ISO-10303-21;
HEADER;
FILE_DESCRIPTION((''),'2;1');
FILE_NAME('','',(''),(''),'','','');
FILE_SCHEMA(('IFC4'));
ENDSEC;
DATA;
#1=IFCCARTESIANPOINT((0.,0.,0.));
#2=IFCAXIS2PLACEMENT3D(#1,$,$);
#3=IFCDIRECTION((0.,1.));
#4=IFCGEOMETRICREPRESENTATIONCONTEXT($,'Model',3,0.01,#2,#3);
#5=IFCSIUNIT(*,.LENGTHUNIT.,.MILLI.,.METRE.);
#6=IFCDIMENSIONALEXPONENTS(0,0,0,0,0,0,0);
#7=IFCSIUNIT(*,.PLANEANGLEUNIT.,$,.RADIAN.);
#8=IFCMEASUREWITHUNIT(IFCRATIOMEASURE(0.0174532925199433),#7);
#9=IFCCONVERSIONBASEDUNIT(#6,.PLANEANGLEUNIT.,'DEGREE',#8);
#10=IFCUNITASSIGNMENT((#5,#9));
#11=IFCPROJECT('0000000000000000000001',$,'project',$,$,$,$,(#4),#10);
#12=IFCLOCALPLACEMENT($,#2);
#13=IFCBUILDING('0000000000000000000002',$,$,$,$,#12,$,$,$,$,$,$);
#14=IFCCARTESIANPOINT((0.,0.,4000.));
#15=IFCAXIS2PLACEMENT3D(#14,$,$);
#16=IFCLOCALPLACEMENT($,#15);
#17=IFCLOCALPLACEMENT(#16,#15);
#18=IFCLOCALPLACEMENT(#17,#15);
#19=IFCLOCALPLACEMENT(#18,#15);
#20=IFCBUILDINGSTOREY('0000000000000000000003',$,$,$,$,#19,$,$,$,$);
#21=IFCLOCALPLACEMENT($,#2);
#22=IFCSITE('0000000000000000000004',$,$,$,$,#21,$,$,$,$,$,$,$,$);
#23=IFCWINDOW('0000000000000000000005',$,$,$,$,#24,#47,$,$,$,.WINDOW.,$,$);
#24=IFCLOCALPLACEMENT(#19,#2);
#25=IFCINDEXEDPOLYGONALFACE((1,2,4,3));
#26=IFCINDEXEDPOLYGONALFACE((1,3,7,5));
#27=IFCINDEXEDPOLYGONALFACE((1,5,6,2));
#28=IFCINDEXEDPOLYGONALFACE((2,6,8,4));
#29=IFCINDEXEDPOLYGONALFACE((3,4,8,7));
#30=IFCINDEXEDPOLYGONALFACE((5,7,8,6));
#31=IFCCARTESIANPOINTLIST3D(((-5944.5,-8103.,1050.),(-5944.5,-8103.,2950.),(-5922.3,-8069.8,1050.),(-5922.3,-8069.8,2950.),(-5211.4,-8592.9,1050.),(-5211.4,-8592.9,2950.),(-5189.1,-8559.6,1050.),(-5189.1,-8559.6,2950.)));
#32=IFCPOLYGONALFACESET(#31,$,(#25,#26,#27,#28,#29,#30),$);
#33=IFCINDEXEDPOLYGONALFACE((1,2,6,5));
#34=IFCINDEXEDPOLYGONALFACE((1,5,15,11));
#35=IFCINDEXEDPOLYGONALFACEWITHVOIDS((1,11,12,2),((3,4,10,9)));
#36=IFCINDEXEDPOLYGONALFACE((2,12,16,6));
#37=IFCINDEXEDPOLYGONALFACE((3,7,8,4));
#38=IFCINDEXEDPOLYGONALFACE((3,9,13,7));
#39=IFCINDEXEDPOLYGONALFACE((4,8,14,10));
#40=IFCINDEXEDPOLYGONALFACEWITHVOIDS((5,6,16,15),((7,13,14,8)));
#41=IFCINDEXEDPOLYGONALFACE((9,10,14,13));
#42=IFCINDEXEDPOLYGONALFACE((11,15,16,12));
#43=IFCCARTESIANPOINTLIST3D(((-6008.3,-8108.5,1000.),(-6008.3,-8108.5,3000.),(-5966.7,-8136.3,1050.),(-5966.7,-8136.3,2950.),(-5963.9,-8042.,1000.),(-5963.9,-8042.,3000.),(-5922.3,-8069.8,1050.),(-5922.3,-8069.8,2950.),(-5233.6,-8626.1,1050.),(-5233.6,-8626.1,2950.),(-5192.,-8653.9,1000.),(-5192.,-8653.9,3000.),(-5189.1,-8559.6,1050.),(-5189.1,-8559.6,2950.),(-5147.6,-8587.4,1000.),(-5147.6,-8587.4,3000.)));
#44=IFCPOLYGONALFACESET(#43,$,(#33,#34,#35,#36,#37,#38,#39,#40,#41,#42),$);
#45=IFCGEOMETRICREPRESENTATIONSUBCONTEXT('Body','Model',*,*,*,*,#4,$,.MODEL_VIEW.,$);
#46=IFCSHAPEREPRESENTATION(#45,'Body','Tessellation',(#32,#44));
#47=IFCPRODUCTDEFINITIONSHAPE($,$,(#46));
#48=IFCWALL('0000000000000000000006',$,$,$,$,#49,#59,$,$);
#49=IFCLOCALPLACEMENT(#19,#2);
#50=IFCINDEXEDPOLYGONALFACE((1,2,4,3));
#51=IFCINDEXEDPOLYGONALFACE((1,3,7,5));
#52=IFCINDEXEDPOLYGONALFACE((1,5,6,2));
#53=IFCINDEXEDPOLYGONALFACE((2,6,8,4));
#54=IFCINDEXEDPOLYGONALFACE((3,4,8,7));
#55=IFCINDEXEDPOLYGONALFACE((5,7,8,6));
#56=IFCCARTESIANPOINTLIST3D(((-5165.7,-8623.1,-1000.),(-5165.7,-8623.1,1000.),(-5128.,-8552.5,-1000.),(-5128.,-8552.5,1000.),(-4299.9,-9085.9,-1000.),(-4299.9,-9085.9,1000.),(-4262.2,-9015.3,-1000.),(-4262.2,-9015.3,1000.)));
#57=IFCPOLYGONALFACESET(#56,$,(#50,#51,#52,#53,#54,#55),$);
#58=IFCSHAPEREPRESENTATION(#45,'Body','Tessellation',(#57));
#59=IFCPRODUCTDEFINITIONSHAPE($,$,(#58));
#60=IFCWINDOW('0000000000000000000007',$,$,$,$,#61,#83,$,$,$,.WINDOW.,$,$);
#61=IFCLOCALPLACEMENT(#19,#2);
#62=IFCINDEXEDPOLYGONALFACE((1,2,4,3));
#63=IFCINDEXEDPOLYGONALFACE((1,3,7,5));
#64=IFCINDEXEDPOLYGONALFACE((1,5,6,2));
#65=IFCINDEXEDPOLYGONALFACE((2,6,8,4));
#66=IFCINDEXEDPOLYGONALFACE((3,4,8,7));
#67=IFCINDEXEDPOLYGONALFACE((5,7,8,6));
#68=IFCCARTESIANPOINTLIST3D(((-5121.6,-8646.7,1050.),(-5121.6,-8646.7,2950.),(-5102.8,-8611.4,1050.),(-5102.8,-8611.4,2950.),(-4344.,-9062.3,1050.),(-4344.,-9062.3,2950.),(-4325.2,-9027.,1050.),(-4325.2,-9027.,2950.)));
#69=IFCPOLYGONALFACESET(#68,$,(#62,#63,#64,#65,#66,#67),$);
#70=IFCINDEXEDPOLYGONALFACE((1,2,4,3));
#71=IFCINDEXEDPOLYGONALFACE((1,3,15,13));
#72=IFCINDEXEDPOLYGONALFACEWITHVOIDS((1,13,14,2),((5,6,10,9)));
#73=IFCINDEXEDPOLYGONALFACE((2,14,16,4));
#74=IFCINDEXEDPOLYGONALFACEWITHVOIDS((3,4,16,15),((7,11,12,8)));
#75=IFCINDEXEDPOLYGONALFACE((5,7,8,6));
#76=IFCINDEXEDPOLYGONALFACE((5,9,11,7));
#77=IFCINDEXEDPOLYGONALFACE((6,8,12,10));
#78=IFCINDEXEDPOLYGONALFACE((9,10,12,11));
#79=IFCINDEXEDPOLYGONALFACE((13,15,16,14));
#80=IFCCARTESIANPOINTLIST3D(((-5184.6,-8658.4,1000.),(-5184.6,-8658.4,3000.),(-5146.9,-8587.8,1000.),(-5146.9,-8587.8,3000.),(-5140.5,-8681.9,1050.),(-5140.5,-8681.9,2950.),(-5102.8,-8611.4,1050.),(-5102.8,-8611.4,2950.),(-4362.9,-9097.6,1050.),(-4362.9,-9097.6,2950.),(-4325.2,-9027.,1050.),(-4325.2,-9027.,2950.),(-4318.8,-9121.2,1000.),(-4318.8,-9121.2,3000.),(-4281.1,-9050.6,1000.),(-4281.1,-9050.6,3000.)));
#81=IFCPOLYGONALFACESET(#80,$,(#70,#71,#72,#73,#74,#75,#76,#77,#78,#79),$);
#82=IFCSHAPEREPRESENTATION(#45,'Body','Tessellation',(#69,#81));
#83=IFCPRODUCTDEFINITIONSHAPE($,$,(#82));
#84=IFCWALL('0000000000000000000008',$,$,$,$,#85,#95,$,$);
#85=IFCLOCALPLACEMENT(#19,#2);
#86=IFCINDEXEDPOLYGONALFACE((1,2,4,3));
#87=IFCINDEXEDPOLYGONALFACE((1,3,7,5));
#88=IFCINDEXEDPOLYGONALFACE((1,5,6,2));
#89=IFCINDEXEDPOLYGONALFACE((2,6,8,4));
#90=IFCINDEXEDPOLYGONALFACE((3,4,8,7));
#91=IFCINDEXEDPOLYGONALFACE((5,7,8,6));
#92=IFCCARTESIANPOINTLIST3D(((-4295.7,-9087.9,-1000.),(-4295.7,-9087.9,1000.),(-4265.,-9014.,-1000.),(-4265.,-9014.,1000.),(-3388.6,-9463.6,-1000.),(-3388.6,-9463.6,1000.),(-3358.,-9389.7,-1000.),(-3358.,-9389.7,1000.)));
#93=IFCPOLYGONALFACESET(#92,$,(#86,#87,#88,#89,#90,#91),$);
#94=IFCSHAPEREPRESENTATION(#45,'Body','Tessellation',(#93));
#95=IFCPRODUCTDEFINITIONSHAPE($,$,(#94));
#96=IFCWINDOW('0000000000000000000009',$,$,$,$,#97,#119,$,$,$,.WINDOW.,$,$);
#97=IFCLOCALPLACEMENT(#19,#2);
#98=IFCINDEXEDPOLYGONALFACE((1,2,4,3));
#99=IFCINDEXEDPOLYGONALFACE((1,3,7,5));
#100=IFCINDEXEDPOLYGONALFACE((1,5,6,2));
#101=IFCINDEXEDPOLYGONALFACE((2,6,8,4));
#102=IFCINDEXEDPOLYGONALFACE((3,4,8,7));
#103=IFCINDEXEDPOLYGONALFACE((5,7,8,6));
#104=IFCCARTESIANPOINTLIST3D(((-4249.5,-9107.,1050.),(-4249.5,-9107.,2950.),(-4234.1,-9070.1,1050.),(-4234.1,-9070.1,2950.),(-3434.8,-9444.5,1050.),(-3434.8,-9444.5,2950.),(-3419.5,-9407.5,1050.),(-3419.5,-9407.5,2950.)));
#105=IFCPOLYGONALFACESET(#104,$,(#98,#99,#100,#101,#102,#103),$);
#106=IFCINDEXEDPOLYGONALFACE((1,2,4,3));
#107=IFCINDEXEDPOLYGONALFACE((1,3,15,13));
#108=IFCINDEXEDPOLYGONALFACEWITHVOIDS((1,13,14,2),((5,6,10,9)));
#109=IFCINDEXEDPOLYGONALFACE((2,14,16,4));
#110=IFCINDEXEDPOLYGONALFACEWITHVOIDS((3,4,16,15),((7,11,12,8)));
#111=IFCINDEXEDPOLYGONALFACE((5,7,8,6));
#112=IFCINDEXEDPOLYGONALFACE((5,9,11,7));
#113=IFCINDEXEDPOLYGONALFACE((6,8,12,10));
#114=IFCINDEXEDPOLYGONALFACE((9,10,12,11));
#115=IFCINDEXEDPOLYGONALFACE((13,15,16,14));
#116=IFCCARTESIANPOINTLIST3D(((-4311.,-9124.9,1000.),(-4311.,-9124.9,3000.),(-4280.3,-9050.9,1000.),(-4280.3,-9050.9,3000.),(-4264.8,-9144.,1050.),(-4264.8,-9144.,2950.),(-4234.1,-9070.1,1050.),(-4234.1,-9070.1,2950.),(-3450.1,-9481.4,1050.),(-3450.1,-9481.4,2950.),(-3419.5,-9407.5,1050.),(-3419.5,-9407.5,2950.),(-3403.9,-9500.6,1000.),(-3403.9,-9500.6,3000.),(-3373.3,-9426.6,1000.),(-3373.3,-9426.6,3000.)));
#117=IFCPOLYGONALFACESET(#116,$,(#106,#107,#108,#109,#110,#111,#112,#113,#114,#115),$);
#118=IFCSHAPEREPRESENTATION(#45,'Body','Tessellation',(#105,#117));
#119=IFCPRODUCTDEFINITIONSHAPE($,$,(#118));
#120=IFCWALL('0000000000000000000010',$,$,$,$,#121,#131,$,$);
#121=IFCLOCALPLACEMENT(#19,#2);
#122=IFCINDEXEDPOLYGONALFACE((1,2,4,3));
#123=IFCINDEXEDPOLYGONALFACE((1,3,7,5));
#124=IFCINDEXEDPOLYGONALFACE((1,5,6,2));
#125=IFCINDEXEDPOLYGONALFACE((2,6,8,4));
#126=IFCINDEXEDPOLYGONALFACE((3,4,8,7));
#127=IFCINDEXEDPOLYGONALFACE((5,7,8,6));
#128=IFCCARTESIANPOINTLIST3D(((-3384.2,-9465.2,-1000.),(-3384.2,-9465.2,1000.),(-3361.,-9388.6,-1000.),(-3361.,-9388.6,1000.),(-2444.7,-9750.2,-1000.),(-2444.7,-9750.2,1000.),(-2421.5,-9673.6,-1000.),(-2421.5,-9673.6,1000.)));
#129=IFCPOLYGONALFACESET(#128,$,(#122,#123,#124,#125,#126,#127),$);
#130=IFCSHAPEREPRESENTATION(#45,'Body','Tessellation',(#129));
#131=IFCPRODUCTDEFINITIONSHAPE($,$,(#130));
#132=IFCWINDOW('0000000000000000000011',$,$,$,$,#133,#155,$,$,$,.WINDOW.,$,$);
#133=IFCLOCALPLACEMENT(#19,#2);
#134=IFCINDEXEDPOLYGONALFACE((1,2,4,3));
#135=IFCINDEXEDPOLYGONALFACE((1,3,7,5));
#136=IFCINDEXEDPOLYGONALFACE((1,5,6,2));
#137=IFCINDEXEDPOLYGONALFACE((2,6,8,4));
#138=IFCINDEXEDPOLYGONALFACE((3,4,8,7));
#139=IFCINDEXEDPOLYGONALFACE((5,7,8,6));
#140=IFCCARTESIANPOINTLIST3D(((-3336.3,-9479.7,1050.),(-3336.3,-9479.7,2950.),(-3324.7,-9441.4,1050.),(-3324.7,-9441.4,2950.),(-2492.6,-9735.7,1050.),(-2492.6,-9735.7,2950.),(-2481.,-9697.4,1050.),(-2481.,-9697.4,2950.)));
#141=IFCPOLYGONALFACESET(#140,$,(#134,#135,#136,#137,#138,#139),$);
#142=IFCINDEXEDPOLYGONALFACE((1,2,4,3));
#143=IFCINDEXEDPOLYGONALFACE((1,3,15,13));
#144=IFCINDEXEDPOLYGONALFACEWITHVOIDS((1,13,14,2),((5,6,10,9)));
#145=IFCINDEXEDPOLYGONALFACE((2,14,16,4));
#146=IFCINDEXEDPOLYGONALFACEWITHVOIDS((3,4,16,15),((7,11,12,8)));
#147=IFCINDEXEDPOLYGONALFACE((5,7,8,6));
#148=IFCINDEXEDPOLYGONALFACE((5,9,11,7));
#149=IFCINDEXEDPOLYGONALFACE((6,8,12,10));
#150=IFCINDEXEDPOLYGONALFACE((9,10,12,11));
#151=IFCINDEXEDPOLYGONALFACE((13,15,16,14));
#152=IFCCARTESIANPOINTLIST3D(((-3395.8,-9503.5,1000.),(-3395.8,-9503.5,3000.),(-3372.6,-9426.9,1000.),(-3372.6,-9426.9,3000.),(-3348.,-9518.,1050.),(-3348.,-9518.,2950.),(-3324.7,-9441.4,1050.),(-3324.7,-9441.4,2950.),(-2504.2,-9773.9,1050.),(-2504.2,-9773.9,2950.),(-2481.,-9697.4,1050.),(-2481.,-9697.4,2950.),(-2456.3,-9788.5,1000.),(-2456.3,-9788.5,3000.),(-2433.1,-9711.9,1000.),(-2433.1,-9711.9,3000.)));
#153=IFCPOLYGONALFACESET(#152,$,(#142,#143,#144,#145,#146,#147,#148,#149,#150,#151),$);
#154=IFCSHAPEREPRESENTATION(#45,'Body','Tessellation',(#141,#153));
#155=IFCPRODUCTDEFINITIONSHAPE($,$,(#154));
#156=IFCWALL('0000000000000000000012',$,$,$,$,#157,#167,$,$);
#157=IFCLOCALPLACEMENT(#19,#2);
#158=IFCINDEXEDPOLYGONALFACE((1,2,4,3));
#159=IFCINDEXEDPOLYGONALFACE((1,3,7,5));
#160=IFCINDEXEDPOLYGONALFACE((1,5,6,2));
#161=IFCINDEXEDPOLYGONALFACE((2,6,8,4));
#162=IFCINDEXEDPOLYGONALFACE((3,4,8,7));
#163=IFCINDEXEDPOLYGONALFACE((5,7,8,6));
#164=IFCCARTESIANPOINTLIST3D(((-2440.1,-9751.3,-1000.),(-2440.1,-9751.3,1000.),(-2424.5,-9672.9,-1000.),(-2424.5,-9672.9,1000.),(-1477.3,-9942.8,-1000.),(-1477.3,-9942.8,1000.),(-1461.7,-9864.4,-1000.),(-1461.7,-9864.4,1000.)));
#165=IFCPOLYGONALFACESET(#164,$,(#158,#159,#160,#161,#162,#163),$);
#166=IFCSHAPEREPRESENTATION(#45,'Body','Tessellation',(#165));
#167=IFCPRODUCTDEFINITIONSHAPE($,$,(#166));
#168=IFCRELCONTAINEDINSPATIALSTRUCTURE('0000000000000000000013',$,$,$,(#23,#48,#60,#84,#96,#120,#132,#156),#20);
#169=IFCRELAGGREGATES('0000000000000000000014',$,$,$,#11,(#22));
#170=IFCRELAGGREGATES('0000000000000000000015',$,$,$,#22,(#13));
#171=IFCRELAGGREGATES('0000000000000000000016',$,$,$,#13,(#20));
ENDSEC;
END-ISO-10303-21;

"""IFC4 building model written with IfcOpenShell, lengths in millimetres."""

from ifc_helpers import new_model, entity, si_unit, converted_unit, direction, frame, origin, origin_2d, place, context, subcontext, project, spatial, rectangle, extrude, element, save


model = new_model("IFC4")

# Units and contexts
model_context = context("Model", 3, precision=0.01, world=origin(), true_north=direction((0.0, 1.0)))
body_context = subcontext(model_context, "Body", "Model", "MODEL_VIEW")
ifc_project = project(units=[si_unit("LENGTHUNIT", "METRE", prefix="MILLI"), converted_unit("PLANEANGLEUNIT", "DEGREE", entity("IfcRatioMeasure", 0.0174532925199433), si_unit("PLANEANGLEUNIT", "RADIAN"), dimensions=[0, 0, 0, 0, 0, 0, 0])], contexts=[model_context])

# Site, building, storey
site_placement = place(None, origin())
site = spatial("IfcSite", under=ifc_project, at=site_placement)
building_placement = place(None, origin())
building = spatial("IfcBuilding", under=site, at=building_placement)
placement_1 = place(None, frame((0.0, 0.0, 4000.0)))
placement_2 = place(placement_1, frame((0.0, 0.0, 4000.0)))
placement_3 = place(placement_2, frame((0.0, 0.0, 4000.0)))
storey_placement = place(placement_3, frame((0.0, 0.0, 4000.0)))
storey = spatial("IfcBuildingStorey", under=building, at=storey_placement)

# Shared definitions
cartesian_point_1 = entity("IfcCartesianPoint", [-440.9, -950.0])
shared_polyline = entity("IfcPolyline", [cartesian_point_1, entity("IfcCartesianPoint", [-440.9, 950.0]), entity("IfcCartesianPoint", [-440.9, 950.0]), entity("IfcCartesianPoint", [440.9, 950.0]), entity("IfcCartesianPoint", [440.9, 950.0]), entity("IfcCartesianPoint", [440.9, -950.0]), entity("IfcCartesianPoint", [440.9, -950.0]), entity("IfcCartesianPoint", [-440.9, -950.0]), cartesian_point_1])

# Window
window_1_placement = place(storey_placement, frame((-5555.7, -8314.7, 2000.0), z_axis=(0.0, 0.0, 1.0), x_axis=(8314.694856, -5555.704226, 0.0)))
cartesian_point_2 = entity("IfcCartesianPoint", [-490.9, -1000.0])
element("IfcWindow", 1, at=window_1_placement, inside=storey, PredefinedType="WINDOW", context=body_context, shape_type="SweptSolid", body=[
    entity("IfcExtrudedAreaSolid", entity("IfcArbitraryClosedProfileDef", "AREA", None, shared_polyline), entity("IfcAxis2Placement3D", entity("IfcCartesianPoint", [0.0, 0.0, 0.0]), entity("IfcDirection", [0.0, -1.0, 0.0]), entity("IfcDirection", [1.0, 0.0, 0.0])), entity("IfcDirection", [0.0, 0.0, 1.0]), 40.0),
    entity("IfcExtrudedAreaSolid", entity("IfcArbitraryProfileDefWithVoids", "AREA", None, entity("IfcPolyline", [cartesian_point_2, entity("IfcCartesianPoint", [-490.9, 1000.0]), entity("IfcCartesianPoint", [-490.9, 1000.0]), entity("IfcCartesianPoint", [490.9, 1000.0]), entity("IfcCartesianPoint", [490.9, 1000.0]), entity("IfcCartesianPoint", [490.9, -1000.0]), entity("IfcCartesianPoint", [490.9, -1000.0]), entity("IfcCartesianPoint", [-490.9, -1000.0]), cartesian_point_2]), [shared_polyline]), entity("IfcAxis2Placement3D", entity("IfcCartesianPoint", [0.0, 0.0, 0.0]), entity("IfcDirection", [0.0, -1.0, 0.0]), entity("IfcDirection", [1.0, 0.0, 0.0])), entity("IfcDirection", [0.0, 0.0, 1.0]), 80.0),
])

# Wall
wall_1_placement = place(storey_placement, frame((-4714.0, -8819.2, -1000.0), z_axis=(0.0, 0.0, 1.0), x_axis=(8819.212881, -4713.966924, 0.0)))
element("IfcWall", 2, at=wall_1_placement, inside=storey, context=body_context, shape_type="SweptSolid", body=[
    extrude(rectangle(XDim=981.7, YDim=80.0, at=origin_2d()), origin(), (0.0, 0.0, 1.0), 2000.0),
])

# Window
window_2_placement = place(storey_placement, frame((-4714.0, -8819.2, 2000.0), z_axis=(0.0, 0.0, 1.0), x_axis=(8819.212881, -4713.966924, 0.0)))
cartesian_point_3 = entity("IfcCartesianPoint", [-490.9, -1000.0])
element("IfcWindow", 3, at=window_2_placement, inside=storey, PredefinedType="WINDOW", context=body_context, shape_type="SweptSolid", body=[
    entity("IfcExtrudedAreaSolid", entity("IfcArbitraryClosedProfileDef", "AREA", None, shared_polyline), entity("IfcAxis2Placement3D", entity("IfcCartesianPoint", [0.0, 0.0, 0.0]), entity("IfcDirection", [0.0, -1.0, 0.0]), entity("IfcDirection", [1.0, 0.0, 0.0])), entity("IfcDirection", [0.0, 0.0, 1.0]), 40.0),
    entity("IfcExtrudedAreaSolid", entity("IfcArbitraryProfileDefWithVoids", "AREA", None, entity("IfcPolyline", [cartesian_point_3, entity("IfcCartesianPoint", [-490.9, 1000.0]), entity("IfcCartesianPoint", [-490.9, 1000.0]), entity("IfcCartesianPoint", [490.9, 1000.0]), entity("IfcCartesianPoint", [490.9, 1000.0]), entity("IfcCartesianPoint", [490.9, -1000.0]), entity("IfcCartesianPoint", [490.9, -1000.0]), entity("IfcCartesianPoint", [-490.9, -1000.0]), cartesian_point_3]), [shared_polyline]), entity("IfcAxis2Placement3D", entity("IfcCartesianPoint", [0.0, 0.0, 0.0]), entity("IfcDirection", [0.0, -1.0, 0.0]), entity("IfcDirection", [1.0, 0.0, 0.0])), entity("IfcDirection", [0.0, 0.0, 1.0]), 80.0),
])

# Wall
wall_2_placement = place(storey_placement, frame((-3826.8, -9238.8, -1000.0), z_axis=(0.0, 0.0, 1.0), x_axis=(9238.794759, -3826.835691, 0.0)))
element("IfcWall", 4, at=wall_2_placement, inside=storey, context=body_context, shape_type="SweptSolid", body=[
    extrude(rectangle(XDim=981.7, YDim=80.0, at=origin_2d()), origin(), (0.0, 0.0, 1.0), 2000.0),
])

# Window
window_3_placement = place(storey_placement, frame((-3826.8, -9238.8, 2000.0), z_axis=(0.0, 0.0, 1.0), x_axis=(9238.794759, -3826.835691, 0.0)))
cartesian_point_4 = entity("IfcCartesianPoint", [-490.9, -1000.0])
element("IfcWindow", 5, at=window_3_placement, inside=storey, PredefinedType="WINDOW", context=body_context, shape_type="SweptSolid", body=[
    entity("IfcExtrudedAreaSolid", entity("IfcArbitraryClosedProfileDef", "AREA", None, shared_polyline), entity("IfcAxis2Placement3D", entity("IfcCartesianPoint", [0.0, 0.0, 0.0]), entity("IfcDirection", [0.0, -1.0, 0.0]), entity("IfcDirection", [1.0, 0.0, 0.0])), entity("IfcDirection", [0.0, 0.0, 1.0]), 40.0),
    entity("IfcExtrudedAreaSolid", entity("IfcArbitraryProfileDefWithVoids", "AREA", None, entity("IfcPolyline", [cartesian_point_4, entity("IfcCartesianPoint", [-490.9, 1000.0]), entity("IfcCartesianPoint", [-490.9, 1000.0]), entity("IfcCartesianPoint", [490.9, 1000.0]), entity("IfcCartesianPoint", [490.9, 1000.0]), entity("IfcCartesianPoint", [490.9, -1000.0]), entity("IfcCartesianPoint", [490.9, -1000.0]), entity("IfcCartesianPoint", [-490.9, -1000.0]), cartesian_point_4]), [shared_polyline]), entity("IfcAxis2Placement3D", entity("IfcCartesianPoint", [0.0, 0.0, 0.0]), entity("IfcDirection", [0.0, -1.0, 0.0]), entity("IfcDirection", [1.0, 0.0, 0.0])), entity("IfcDirection", [0.0, 0.0, 1.0]), 80.0),
])

# Wall
wall_3_placement = place(storey_placement, frame((-2902.8, -9569.4, -1000.0), z_axis=(0.0, 0.0, 1.0), x_axis=(9569.403736, -2902.845525, 0.0)))
element("IfcWall", 6, at=wall_3_placement, inside=storey, context=body_context, shape_type="SweptSolid", body=[
    extrude(rectangle(XDim=981.7, YDim=80.0, at=origin_2d()), origin(), (0.0, 0.0, 1.0), 2000.0),
])

# Window
window_4_placement = place(storey_placement, frame((-2902.8, -9569.4, 2000.0), z_axis=(0.0, 0.0, 1.0), x_axis=(9569.403736, -2902.845525, 0.0)))
cartesian_point_5 = entity("IfcCartesianPoint", [-490.9, -1000.0])
element("IfcWindow", 7, at=window_4_placement, inside=storey, PredefinedType="WINDOW", context=body_context, shape_type="SweptSolid", body=[
    entity("IfcExtrudedAreaSolid", entity("IfcArbitraryClosedProfileDef", "AREA", None, shared_polyline), entity("IfcAxis2Placement3D", entity("IfcCartesianPoint", [0.0, 0.0, 0.0]), entity("IfcDirection", [0.0, -1.0, 0.0]), entity("IfcDirection", [1.0, 0.0, 0.0])), entity("IfcDirection", [0.0, 0.0, 1.0]), 40.0),
    entity("IfcExtrudedAreaSolid", entity("IfcArbitraryProfileDefWithVoids", "AREA", None, entity("IfcPolyline", [cartesian_point_5, entity("IfcCartesianPoint", [-490.9, 1000.0]), entity("IfcCartesianPoint", [-490.9, 1000.0]), entity("IfcCartesianPoint", [490.9, 1000.0]), entity("IfcCartesianPoint", [490.9, 1000.0]), entity("IfcCartesianPoint", [490.9, -1000.0]), entity("IfcCartesianPoint", [490.9, -1000.0]), entity("IfcCartesianPoint", [-490.9, -1000.0]), cartesian_point_5]), [shared_polyline]), entity("IfcAxis2Placement3D", entity("IfcCartesianPoint", [0.0, 0.0, 0.0]), entity("IfcDirection", [0.0, -1.0, 0.0]), entity("IfcDirection", [1.0, 0.0, 0.0])), entity("IfcDirection", [0.0, 0.0, 1.0]), 80.0),
])

# Wall
wall_4_placement = place(storey_placement, frame((-1950.9, -9807.9, -1000.0), z_axis=(0.0, 0.0, 1.0), x_axis=(9807.852671, -1950.903888, 0.0)))
element("IfcWall", 8, at=wall_4_placement, inside=storey, context=body_context, shape_type="SweptSolid", body=[
    extrude(rectangle(XDim=981.7, YDim=80.0, at=origin_2d()), origin(), (0.0, 0.0, 1.0), 2000.0),
])

save(model, "model.ifc")
